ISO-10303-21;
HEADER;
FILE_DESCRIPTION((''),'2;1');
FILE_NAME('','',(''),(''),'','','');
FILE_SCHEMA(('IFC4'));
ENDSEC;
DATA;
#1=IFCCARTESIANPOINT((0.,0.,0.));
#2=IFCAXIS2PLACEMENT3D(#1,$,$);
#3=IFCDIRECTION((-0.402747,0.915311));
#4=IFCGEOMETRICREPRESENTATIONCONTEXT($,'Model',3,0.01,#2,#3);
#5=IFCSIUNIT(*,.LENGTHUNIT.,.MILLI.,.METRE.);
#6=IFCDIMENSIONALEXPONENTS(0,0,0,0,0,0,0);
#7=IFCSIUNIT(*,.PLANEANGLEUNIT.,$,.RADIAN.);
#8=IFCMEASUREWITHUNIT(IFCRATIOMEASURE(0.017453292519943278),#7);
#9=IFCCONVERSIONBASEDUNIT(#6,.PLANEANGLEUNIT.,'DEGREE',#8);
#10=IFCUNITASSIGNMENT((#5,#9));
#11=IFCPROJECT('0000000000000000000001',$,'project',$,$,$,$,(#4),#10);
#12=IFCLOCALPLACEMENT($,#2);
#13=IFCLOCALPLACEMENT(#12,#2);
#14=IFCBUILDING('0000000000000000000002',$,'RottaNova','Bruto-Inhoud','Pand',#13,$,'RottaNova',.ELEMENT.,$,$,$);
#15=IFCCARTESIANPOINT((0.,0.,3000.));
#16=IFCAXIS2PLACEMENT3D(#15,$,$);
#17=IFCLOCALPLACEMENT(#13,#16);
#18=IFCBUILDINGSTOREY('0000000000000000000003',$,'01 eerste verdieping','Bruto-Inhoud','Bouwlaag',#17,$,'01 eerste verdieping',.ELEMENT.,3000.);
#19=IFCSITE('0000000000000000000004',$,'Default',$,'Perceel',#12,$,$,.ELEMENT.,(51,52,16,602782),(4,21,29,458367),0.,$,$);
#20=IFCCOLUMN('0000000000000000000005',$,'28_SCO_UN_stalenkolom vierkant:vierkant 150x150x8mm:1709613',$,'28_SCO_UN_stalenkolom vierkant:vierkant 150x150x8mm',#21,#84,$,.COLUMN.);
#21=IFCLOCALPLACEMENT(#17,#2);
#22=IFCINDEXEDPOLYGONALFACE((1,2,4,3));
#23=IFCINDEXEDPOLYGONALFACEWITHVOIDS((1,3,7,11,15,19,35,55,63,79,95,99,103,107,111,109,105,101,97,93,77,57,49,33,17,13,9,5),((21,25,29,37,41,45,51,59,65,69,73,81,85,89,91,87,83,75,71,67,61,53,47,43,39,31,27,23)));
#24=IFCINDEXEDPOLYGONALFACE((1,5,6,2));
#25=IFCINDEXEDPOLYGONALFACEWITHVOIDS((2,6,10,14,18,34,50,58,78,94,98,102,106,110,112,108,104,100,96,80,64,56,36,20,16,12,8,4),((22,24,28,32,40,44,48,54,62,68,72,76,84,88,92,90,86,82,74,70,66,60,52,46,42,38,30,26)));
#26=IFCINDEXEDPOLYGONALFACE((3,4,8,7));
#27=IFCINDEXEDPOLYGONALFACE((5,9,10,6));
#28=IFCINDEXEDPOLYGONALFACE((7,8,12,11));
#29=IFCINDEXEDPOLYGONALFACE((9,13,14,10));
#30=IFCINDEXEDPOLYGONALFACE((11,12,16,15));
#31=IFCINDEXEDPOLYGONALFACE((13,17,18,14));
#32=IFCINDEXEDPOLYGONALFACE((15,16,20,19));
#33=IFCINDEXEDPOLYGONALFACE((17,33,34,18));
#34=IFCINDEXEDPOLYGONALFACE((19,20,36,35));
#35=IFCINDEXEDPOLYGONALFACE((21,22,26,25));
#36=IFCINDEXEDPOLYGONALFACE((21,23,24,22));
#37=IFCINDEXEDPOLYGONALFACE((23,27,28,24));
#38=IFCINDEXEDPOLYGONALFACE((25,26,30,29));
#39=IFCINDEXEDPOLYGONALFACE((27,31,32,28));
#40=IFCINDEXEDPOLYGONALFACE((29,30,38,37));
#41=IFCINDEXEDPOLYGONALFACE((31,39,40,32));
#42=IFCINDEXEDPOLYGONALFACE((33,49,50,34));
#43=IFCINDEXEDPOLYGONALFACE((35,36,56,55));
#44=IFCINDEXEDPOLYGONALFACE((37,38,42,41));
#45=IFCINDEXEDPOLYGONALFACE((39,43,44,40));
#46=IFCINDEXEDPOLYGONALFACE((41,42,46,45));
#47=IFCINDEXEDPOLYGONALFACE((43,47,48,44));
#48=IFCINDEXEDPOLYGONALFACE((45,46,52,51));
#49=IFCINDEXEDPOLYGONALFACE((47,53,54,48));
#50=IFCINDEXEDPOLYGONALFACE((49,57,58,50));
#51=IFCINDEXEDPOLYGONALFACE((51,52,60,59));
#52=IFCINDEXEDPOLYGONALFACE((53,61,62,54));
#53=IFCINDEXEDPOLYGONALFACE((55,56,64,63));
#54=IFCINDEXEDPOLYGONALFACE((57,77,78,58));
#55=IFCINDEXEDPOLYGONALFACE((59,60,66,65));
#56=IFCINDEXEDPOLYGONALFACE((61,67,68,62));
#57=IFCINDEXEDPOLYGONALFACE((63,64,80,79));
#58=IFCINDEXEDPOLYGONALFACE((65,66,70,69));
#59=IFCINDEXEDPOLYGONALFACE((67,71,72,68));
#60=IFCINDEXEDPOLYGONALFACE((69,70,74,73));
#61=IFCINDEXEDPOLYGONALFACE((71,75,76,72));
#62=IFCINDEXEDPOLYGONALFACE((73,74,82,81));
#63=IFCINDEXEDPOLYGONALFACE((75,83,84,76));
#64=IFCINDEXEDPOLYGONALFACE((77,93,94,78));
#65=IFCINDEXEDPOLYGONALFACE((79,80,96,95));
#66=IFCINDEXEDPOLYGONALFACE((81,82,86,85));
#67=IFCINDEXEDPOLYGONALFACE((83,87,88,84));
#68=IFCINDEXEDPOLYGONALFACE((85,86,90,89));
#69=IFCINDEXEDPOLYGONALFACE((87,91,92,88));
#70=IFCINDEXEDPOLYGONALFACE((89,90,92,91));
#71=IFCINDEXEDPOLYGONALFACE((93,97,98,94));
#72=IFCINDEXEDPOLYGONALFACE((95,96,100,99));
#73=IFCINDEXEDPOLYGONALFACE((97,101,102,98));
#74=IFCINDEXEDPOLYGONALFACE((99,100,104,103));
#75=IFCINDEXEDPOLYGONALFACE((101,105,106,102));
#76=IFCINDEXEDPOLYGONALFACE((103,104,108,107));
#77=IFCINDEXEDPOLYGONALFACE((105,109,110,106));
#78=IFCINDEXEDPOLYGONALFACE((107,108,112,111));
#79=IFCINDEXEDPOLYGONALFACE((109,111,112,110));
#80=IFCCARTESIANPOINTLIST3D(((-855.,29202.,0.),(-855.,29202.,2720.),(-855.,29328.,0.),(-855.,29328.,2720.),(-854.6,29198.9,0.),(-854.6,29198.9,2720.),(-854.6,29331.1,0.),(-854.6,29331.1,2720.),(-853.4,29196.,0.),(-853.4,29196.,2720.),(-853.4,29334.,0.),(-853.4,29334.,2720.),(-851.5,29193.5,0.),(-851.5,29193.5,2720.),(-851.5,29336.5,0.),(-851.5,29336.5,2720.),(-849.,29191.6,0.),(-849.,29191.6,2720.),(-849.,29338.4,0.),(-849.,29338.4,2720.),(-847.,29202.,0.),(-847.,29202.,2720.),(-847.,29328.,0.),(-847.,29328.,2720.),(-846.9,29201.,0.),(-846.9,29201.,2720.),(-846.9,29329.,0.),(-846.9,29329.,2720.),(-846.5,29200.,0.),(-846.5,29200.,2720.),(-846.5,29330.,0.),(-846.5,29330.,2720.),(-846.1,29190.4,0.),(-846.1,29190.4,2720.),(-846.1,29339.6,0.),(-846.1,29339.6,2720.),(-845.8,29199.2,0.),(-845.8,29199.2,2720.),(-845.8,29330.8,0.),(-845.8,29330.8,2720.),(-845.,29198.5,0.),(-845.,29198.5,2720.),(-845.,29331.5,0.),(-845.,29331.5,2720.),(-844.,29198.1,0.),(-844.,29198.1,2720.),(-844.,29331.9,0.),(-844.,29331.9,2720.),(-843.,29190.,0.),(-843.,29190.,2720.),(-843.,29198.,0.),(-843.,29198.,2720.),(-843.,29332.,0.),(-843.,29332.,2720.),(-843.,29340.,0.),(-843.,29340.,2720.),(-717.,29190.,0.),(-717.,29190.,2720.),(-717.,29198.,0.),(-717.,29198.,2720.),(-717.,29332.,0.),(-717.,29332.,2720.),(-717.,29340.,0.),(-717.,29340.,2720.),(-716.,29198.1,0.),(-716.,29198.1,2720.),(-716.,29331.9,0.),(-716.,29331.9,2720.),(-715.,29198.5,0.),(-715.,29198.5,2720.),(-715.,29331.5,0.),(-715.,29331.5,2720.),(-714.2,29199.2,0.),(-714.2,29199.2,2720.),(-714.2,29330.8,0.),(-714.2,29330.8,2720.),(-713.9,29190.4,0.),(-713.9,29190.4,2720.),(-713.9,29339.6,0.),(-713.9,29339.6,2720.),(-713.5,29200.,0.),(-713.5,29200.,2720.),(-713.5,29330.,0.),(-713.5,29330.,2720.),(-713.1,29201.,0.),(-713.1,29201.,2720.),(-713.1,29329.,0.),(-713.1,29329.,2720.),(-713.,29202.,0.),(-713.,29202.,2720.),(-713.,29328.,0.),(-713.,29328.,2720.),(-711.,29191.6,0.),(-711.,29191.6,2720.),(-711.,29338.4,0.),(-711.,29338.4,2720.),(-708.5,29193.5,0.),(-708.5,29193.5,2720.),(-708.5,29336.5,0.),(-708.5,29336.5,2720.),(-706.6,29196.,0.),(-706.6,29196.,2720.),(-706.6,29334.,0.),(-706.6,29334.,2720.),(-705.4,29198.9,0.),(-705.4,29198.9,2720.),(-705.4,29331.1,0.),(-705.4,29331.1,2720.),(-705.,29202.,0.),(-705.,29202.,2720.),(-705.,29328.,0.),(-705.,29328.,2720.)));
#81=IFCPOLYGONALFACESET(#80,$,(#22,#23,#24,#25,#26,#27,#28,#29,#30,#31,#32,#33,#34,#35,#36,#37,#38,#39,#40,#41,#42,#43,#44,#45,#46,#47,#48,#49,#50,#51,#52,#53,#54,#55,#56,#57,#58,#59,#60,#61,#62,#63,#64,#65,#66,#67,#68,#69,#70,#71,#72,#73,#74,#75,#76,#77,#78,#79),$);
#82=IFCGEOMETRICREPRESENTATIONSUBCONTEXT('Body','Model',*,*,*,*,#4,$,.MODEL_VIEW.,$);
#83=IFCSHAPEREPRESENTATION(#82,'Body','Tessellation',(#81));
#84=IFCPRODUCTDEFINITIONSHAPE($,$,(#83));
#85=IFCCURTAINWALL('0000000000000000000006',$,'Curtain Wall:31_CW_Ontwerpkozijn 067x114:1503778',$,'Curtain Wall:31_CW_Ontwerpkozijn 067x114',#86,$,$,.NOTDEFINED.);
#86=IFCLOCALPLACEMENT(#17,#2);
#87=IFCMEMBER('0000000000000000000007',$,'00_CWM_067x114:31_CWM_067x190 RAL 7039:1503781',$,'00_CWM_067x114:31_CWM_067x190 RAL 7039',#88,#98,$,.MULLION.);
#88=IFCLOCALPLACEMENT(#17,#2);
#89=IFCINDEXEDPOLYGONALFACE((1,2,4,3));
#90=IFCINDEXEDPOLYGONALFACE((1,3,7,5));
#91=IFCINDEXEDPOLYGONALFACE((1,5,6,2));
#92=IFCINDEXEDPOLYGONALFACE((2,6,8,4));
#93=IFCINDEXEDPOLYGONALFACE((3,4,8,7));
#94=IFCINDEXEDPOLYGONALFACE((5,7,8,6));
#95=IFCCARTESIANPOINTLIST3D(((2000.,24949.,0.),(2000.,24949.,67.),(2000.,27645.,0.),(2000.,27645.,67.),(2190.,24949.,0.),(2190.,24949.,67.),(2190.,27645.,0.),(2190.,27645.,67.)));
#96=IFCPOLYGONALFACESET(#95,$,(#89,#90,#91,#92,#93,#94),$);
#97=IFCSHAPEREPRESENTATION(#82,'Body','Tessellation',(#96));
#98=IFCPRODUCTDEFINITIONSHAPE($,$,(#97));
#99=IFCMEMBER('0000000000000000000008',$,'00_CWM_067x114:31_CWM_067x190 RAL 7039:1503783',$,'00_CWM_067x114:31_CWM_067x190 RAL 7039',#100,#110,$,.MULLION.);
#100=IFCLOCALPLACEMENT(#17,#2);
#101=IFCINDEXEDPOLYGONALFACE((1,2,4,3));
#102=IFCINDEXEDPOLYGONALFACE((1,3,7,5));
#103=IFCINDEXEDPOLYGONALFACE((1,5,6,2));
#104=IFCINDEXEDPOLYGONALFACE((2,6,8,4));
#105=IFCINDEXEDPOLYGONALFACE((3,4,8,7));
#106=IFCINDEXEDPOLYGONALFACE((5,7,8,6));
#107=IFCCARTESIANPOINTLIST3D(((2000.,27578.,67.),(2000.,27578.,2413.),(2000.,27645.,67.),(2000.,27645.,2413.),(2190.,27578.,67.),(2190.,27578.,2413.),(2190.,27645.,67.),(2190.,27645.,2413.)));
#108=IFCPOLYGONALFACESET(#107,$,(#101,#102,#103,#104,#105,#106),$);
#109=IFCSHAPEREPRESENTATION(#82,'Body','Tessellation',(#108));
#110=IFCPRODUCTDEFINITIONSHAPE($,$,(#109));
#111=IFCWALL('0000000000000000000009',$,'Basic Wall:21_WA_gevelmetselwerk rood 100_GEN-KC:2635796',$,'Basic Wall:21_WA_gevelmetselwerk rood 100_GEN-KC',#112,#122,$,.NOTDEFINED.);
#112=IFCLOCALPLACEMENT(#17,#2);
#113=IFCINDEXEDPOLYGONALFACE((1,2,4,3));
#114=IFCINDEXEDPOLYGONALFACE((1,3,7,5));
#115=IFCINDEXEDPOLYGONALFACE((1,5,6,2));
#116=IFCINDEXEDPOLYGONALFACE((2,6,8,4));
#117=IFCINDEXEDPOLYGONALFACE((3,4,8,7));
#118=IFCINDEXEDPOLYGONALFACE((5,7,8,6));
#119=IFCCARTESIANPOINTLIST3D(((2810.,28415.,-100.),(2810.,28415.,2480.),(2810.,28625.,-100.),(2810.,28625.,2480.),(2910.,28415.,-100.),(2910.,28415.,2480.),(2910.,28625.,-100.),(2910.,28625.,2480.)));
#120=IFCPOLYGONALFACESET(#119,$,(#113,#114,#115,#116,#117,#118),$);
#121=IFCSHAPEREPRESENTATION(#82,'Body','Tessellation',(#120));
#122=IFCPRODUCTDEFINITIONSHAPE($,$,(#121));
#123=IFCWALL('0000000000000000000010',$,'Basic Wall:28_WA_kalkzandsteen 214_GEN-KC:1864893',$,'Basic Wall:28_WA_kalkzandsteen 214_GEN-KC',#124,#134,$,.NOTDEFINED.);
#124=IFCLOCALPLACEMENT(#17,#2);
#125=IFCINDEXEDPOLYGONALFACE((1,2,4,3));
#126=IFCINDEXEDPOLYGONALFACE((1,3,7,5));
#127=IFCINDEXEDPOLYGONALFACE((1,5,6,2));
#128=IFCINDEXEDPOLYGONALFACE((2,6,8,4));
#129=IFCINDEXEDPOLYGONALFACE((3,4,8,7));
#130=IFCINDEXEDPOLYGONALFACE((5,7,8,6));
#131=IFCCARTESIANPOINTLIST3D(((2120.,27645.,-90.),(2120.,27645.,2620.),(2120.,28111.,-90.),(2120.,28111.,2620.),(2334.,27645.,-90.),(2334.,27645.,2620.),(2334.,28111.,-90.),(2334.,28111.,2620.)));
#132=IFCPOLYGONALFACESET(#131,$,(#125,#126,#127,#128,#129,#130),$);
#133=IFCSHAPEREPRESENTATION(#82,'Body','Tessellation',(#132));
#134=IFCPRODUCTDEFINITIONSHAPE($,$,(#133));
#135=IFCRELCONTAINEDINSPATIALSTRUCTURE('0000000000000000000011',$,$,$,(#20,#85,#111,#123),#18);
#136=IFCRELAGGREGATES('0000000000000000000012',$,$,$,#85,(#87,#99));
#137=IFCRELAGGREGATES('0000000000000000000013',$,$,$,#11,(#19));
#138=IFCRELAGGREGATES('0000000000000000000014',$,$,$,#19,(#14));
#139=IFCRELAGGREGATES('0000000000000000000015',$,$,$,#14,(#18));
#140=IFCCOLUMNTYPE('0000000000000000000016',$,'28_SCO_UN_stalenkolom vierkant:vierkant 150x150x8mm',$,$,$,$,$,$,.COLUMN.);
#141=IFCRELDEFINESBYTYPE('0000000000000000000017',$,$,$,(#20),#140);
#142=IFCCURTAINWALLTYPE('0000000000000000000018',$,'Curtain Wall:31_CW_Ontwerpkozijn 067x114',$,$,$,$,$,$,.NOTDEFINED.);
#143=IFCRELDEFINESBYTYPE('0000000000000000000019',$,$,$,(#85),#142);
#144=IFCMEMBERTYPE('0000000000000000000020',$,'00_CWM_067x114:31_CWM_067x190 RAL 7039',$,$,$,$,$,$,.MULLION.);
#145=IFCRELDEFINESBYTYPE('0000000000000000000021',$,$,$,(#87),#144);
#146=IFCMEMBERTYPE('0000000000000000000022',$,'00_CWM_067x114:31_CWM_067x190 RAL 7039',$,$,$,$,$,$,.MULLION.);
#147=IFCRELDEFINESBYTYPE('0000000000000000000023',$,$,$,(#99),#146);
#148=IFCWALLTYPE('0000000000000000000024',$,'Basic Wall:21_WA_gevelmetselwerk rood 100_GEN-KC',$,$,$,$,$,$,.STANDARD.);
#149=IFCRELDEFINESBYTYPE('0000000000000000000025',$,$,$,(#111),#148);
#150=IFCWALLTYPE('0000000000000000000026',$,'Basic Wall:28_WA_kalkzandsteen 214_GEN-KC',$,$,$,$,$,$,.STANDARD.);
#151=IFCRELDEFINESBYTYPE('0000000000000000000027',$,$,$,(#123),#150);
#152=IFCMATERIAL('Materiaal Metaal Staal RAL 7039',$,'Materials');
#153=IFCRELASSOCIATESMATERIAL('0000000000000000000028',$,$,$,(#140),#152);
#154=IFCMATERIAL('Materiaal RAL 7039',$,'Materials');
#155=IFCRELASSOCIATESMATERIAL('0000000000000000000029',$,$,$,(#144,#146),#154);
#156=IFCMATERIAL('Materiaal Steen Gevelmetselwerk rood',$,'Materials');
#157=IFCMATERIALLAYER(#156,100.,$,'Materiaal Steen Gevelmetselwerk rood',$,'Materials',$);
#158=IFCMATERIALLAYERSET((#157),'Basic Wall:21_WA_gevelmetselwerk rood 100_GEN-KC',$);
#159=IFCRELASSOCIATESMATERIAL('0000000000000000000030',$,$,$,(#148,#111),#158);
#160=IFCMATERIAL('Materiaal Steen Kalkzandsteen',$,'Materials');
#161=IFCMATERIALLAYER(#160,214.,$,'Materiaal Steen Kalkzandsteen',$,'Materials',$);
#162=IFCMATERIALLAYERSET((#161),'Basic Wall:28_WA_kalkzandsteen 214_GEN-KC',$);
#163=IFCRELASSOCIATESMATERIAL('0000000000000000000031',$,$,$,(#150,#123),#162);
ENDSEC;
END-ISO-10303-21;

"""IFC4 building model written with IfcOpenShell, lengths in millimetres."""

from ifc_helpers import new_model, entity, si_unit, converted_unit, direction, frame, frame_2d, origin, origin_2d_with_axis, place, context, subcontext, project, spatial, polyline, circle_curve, parameter, trimmed, segment, composite_curve, rectangle, outline, extrude, source, transform, mapped, material, layer, layer_set, material_profile, profile_set, type_object, type_shapes, element, aggregate, save


model = new_model("IFC4")

# Units and contexts
model_context = context("Model", 3, precision=0.01, world=origin(), true_north=direction((-0.402747, 0.915311)))
body_context = subcontext(model_context, "Body", "Model", "MODEL_VIEW")
ifc_project = project(units=[si_unit("LENGTHUNIT", "METRE", prefix="MILLI"), converted_unit("PLANEANGLEUNIT", "DEGREE", entity("IfcRatioMeasure", 0.017453292519943278), si_unit("PLANEANGLEUNIT", "RADIAN"), dimensions=[0, 0, 0, 0, 0, 0, 0])], contexts=[model_context])

# Site, building, storey
site_placement = place(None, origin())
site = spatial("IfcSite", under=ifc_project, at=site_placement, Name="Default", ObjectType="Perceel", CompositionType="ELEMENT", RefLatitude=(51, 52, 16, 602782), RefLongitude=(4, 21, 29, 458367), RefElevation=0.0)
building_placement = place(site_placement, origin())
building = spatial("IfcBuilding", under=site, at=building_placement, Name="RottaNova", Description="Bruto-Inhoud", ObjectType="Pand", LongName="RottaNova", CompositionType="ELEMENT")
storey_placement = place(building_placement, frame((0.0, 0.0, 3000.0)))
storey = spatial("IfcBuildingStorey", under=building, at=storey_placement, Name="01 eerste verdieping", Description="Bruto-Inhoud", ObjectType="Bouwlaag", LongName="01 eerste verdieping", CompositionType="ELEMENT", Elevation=3000.0)

# Column
ifc_material_1 = material(Name="Materiaal Metaal Staal RAL 7039", Category="Materials")
ifc_material_profile_1 = material_profile(ifc_material_1, outline(composite_curve([segment(trimmed(circle_curve(frame_2d((63.0, -63.0), x_axis=(1.0, 0.0)), 12.0), [parameter(270.0)], [parameter(360.0)], True, "PARAMETER"), True, "CONTINUOUS"), segment(polyline([(75.0, -63.0), (75.0, 63.0)]), True, "CONTINUOUS"), segment(trimmed(circle_curve(frame_2d((63.0, 63.0), x_axis=(1.0, 0.0)), 12.0), [parameter(360.0)], [parameter(90.0)], True, "PARAMETER"), True, "CONTINUOUS"), segment(polyline([(63.0, 75.0), (-63.0, 75.0)]), True, "CONTINUOUS"), segment(trimmed(circle_curve(frame_2d((-63.0, 63.0), x_axis=(1.0, 0.0)), 12.0), [parameter(90.0)], [parameter(180.0)], True, "PARAMETER"), True, "CONTINUOUS"), segment(polyline([(-75.0, 63.0), (-75.0, -63.0)]), True, "CONTINUOUS"), segment(trimmed(circle_curve(frame_2d((-63.0, -63.0), x_axis=(1.0, 0.0)), 12.0), [parameter(180.0)], [parameter(270.0)], True, "PARAMETER"), True, "CONTINUOUS"), segment(polyline([(-63.0, -75.0), (63.0, -75.0)]), True, "CONTINUOUS")], self_intersect=False), holes=[composite_curve([segment(polyline([(-67.0, -63.0), (-67.0, 63.0)]), True, "CONTINUOUS"), segment(trimmed(circle_curve(frame_2d((-63.0, 63.0), x_axis=(1.0, 0.0)), 4.0), [parameter(90.0)], [parameter(180.0)], True, "PARAMETER"), False, "CONTINUOUS"), segment(polyline([(-63.0, 67.0), (63.0, 67.0)]), True, "CONTINUOUS"), segment(trimmed(circle_curve(frame_2d((63.0, 63.0), x_axis=(1.0, 0.0)), 4.0), [parameter(0.0)], [parameter(90.0)], True, "PARAMETER"), False, "CONTINUOUS"), segment(polyline([(67.0, 63.0), (67.0, -63.0)]), True, "CONTINUOUS"), segment(trimmed(circle_curve(frame_2d((63.0, -63.0), x_axis=(1.0, 0.0)), 4.0), [parameter(270.0)], [parameter(0.0)], True, "PARAMETER"), False, "CONTINUOUS"), segment(polyline([(63.0, -67.0), (-63.0, -67.0)]), True, "CONTINUOUS"), segment(trimmed(circle_curve(frame_2d((-63.0, -63.0), x_axis=(1.0, 0.0)), 4.0), [parameter(180.0)], [parameter(270.0)], True, "PARAMETER"), False, "CONTINUOUS")], self_intersect=False)]), Name="vierkant 150x150x8mm")
ifc_profile_set_1 = profile_set([ifc_material_profile_1], Name="vierkant 150x150x8mm")
column_type = type_object("IfcColumnType", Name="28_SCO_UN_stalenkolom vierkant:vierkant 150x150x8mm", PredefinedType="COLUMN", material=ifc_profile_set_1)
shared_shape_1 = source(origin(), body_context, "Body", "SweptSolid", [
    extrude(outline(composite_curve([segment(trimmed(circle_curve(frame_2d((63.0, -63.0), x_axis=(1.0, 0.0)), 12.0), [parameter(270.0)], [parameter(360.0)], True, "PARAMETER"), True, "CONTINUOUS"), segment(polyline([(75.0, -63.0), (75.0, 63.0)]), True, "CONTINUOUS"), segment(trimmed(circle_curve(frame_2d((63.0, 63.0), x_axis=(1.0, 0.0)), 12.0), [parameter(360.0)], [parameter(90.0)], True, "PARAMETER"), True, "CONTINUOUS"), segment(polyline([(63.0, 75.0), (-63.0, 75.0)]), True, "CONTINUOUS"), segment(trimmed(circle_curve(frame_2d((-63.0, 63.0), x_axis=(1.0, 0.0)), 12.0), [parameter(90.0)], [parameter(180.0)], True, "PARAMETER"), True, "CONTINUOUS"), segment(polyline([(-75.0, 63.0), (-75.0, -63.0)]), True, "CONTINUOUS"), segment(trimmed(circle_curve(frame_2d((-63.0, -63.0), x_axis=(1.0, 0.0)), 12.0), [parameter(180.0)], [parameter(270.0)], True, "PARAMETER"), True, "CONTINUOUS"), segment(polyline([(-63.0, -75.0), (63.0, -75.0)]), True, "CONTINUOUS")], self_intersect=False), holes=[composite_curve([segment(polyline([(-67.0, -63.0), (-67.0, 63.0)]), True, "CONTINUOUS"), segment(trimmed(circle_curve(frame_2d((-63.0, 63.0), x_axis=(1.0, 0.0)), 4.0), [parameter(90.0)], [parameter(180.0)], True, "PARAMETER"), False, "CONTINUOUS"), segment(polyline([(-63.0, 67.0), (63.0, 67.0)]), True, "CONTINUOUS"), segment(trimmed(circle_curve(frame_2d((63.0, 63.0), x_axis=(1.0, 0.0)), 4.0), [parameter(0.0)], [parameter(90.0)], True, "PARAMETER"), False, "CONTINUOUS"), segment(polyline([(67.0, 63.0), (67.0, -63.0)]), True, "CONTINUOUS"), segment(trimmed(circle_curve(frame_2d((63.0, -63.0), x_axis=(1.0, 0.0)), 4.0), [parameter(270.0)], [parameter(0.0)], True, "PARAMETER"), False, "CONTINUOUS"), segment(polyline([(63.0, -67.0), (-63.0, -67.0)]), True, "CONTINUOUS"), segment(trimmed(circle_curve(frame_2d((-63.0, -63.0), x_axis=(1.0, 0.0)), 4.0), [parameter(180.0)], [parameter(270.0)], True, "PARAMETER"), False, "CONTINUOUS")], self_intersect=False)]), frame((76.6, 76.6, 0.0)), (0.0, 0.0, 1.0), 2720.0),
])
type_shapes(column_type, [shared_shape_1])
column_placement = place(storey_placement, frame((-703.4, 29341.6, 0.0), z_axis=(0.0, 0.0, 1.0), x_axis=(-1.0, 0.0, 0.0)))
element("IfcColumn", 1, at=column_placement, inside=storey, type_object=column_type, Name="28_SCO_UN_stalenkolom vierkant:vierkant 150x150x8mm:1709613", ObjectType="28_SCO_UN_stalenkolom vierkant:vierkant 150x150x8mm", PredefinedType="COLUMN", context=body_context, shape_type="MappedRepresentation", body=[
    mapped(shared_shape_1, transform((0.0, 0.0, 0.0), scale=1.0)),
])

# Curtain wall, members
curtain_wall_type = type_object("IfcCurtainWallType", Name="Curtain Wall:31_CW_Ontwerpkozijn 067x114", PredefinedType="NOTDEFINED")
curtain_wall_placement = place(storey_placement, frame((0.0, 0.0, -3000.0)))
curtain_wall = element("IfcCurtainWall", 2, at=curtain_wall_placement, inside=storey, type_object=curtain_wall_type, Name="Curtain Wall:31_CW_Ontwerpkozijn 067x114:1503778", ObjectType="Curtain Wall:31_CW_Ontwerpkozijn 067x114", PredefinedType="NOTDEFINED")
ifc_material_2 = material(Name="Materiaal RAL 7039", Category="Materials")
ifc_material_profile_2 = material_profile(ifc_material_2, rectangle(XDim=190.0, YDim=67.0, at=origin_2d_with_axis()), Name="31_CWM_067x190 RAL 7039")
ifc_profile_set_2 = profile_set([ifc_material_profile_2], Name="31_CWM_067x190 RAL 7039")
member_type_1 = type_object("IfcMemberType", Name="00_CWM_067x114:31_CWM_067x190 RAL 7039", PredefinedType="MULLION", material=ifc_profile_set_2)
shared_shape_2 = source(origin(), body_context, "Body", "SweptSolid", [
    extrude(rectangle(XDim=190.0, YDim=67.0, at=origin_2d_with_axis()), frame((-33.5, 95.0, -2696.0), z_axis=(0.0, 0.0, 1.0), x_axis=(0.0, -1.0, 0.0)), (0.0, 0.0, 1.0), 2696.0),
])
type_shapes(member_type_1, [shared_shape_2])
member_1_placement = place(curtain_wall_placement, frame((2190.0, 27645.0, 3000.0), z_axis=(0.0, 1.0, 0.0), x_axis=(0.0, 0.0, -1.0)))
member_1 = element("IfcMember", 3, at=member_1_placement, type_object=member_type_1, Name="00_CWM_067x114:31_CWM_067x190 RAL 7039:1503781", ObjectType="00_CWM_067x114:31_CWM_067x190 RAL 7039", PredefinedType="MULLION", context=body_context, shape_type="MappedRepresentation", body=[
    mapped(shared_shape_2, transform((0.0, 0.0, 0.0), scale=1.0)),
])
member_type_2 = type_object("IfcMemberType", Name="00_CWM_067x114:31_CWM_067x190 RAL 7039", PredefinedType="MULLION", material=ifc_profile_set_2)
shared_shape_3 = source(origin(), body_context, "Body", "SweptSolid", [
    extrude(rectangle(XDim=190.0, YDim=67.0, at=origin_2d_with_axis()), frame((-33.5, 95.0, -2346.0), z_axis=(0.0, 0.0, 1.0), x_axis=(0.0, -1.0, 0.0)), (0.0, 0.0, 1.0), 2346.0),
])
type_shapes(member_type_2, [shared_shape_3])
member_2_placement = place(curtain_wall_placement, frame((2190.0, 27645.0, 5413.0), z_axis=(0.0, 0.0, 1.0), x_axis=(0.0, 1.0, 0.0)))
member_2 = element("IfcMember", 4, at=member_2_placement, type_object=member_type_2, Name="00_CWM_067x114:31_CWM_067x190 RAL 7039:1503783", ObjectType="00_CWM_067x114:31_CWM_067x190 RAL 7039", PredefinedType="MULLION", context=body_context, shape_type="MappedRepresentation", body=[
    mapped(shared_shape_3, transform((0.0, 0.0, 0.0), scale=1.0)),
])
aggregate(curtain_wall, [member_1, member_2])

# Shared definitions
ifc_material_3 = material(Name="Materiaal Steen Gevelmetselwerk rood", Category="Materials")
ifc_layer_1 = layer(ifc_material_3, 100.0, Name="Materiaal Steen Gevelmetselwerk rood", Category="Materials")
ifc_layer_set_1 = layer_set([ifc_layer_1], Name="Basic Wall:21_WA_gevelmetselwerk rood 100_GEN-KC")
wall_type_1 = type_object("IfcWallType", Name="Basic Wall:21_WA_gevelmetselwerk rood 100_GEN-KC", PredefinedType="STANDARD", material=ifc_layer_set_1)

# Wall
wall_1_placement = place(storey_placement, frame((2860.0, 28415.0, -100.0), z_axis=(0.0, 0.0, 1.0), x_axis=(0.0, 1.0, 0.0)))
element("IfcWall", 5, at=wall_1_placement, inside=storey, type_object=wall_type_1, material=ifc_layer_set_1, Name="Basic Wall:21_WA_gevelmetselwerk rood 100_GEN-KC:2635796", ObjectType="Basic Wall:21_WA_gevelmetselwerk rood 100_GEN-KC", PredefinedType="NOTDEFINED", context=body_context, shape_type="SweptSolid", body=[
    extrude(rectangle(XDim=210.0, YDim=100.0, at=frame_2d((105.0, 0.0), x_axis=(-1.0, 0.0))), origin(), (0.0, 0.0, 1.0), 2580.0),
])

# Shared definitions
ifc_material_4 = material(Name="Materiaal Steen Kalkzandsteen", Category="Materials")
ifc_layer_2 = layer(ifc_material_4, 214.0, Name="Materiaal Steen Kalkzandsteen", Category="Materials")
ifc_layer_set_2 = layer_set([ifc_layer_2], Name="Basic Wall:28_WA_kalkzandsteen 214_GEN-KC")
wall_type_2 = type_object("IfcWallType", Name="Basic Wall:28_WA_kalkzandsteen 214_GEN-KC", PredefinedType="STANDARD", material=ifc_layer_set_2)

# Wall
wall_2_placement = place(storey_placement, frame((2227.0, 28111.0, -90.0), z_axis=(0.0, 0.0, 1.0), x_axis=(0.0, -1.0, 0.0)))
element("IfcWall", 6, at=wall_2_placement, inside=storey, type_object=wall_type_2, material=ifc_layer_set_2, Name="Basic Wall:28_WA_kalkzandsteen 214_GEN-KC:1864893", ObjectType="Basic Wall:28_WA_kalkzandsteen 214_GEN-KC", PredefinedType="NOTDEFINED", context=body_context, shape_type="SweptSolid", body=[
    extrude(rectangle(XDim=466.0, YDim=214.0, at=frame_2d((233.0, 0.0), x_axis=(-1.0, 0.0))), origin(), (0.0, 0.0, 1.0), 2710.0),
])

save(model, "model.ifc")
